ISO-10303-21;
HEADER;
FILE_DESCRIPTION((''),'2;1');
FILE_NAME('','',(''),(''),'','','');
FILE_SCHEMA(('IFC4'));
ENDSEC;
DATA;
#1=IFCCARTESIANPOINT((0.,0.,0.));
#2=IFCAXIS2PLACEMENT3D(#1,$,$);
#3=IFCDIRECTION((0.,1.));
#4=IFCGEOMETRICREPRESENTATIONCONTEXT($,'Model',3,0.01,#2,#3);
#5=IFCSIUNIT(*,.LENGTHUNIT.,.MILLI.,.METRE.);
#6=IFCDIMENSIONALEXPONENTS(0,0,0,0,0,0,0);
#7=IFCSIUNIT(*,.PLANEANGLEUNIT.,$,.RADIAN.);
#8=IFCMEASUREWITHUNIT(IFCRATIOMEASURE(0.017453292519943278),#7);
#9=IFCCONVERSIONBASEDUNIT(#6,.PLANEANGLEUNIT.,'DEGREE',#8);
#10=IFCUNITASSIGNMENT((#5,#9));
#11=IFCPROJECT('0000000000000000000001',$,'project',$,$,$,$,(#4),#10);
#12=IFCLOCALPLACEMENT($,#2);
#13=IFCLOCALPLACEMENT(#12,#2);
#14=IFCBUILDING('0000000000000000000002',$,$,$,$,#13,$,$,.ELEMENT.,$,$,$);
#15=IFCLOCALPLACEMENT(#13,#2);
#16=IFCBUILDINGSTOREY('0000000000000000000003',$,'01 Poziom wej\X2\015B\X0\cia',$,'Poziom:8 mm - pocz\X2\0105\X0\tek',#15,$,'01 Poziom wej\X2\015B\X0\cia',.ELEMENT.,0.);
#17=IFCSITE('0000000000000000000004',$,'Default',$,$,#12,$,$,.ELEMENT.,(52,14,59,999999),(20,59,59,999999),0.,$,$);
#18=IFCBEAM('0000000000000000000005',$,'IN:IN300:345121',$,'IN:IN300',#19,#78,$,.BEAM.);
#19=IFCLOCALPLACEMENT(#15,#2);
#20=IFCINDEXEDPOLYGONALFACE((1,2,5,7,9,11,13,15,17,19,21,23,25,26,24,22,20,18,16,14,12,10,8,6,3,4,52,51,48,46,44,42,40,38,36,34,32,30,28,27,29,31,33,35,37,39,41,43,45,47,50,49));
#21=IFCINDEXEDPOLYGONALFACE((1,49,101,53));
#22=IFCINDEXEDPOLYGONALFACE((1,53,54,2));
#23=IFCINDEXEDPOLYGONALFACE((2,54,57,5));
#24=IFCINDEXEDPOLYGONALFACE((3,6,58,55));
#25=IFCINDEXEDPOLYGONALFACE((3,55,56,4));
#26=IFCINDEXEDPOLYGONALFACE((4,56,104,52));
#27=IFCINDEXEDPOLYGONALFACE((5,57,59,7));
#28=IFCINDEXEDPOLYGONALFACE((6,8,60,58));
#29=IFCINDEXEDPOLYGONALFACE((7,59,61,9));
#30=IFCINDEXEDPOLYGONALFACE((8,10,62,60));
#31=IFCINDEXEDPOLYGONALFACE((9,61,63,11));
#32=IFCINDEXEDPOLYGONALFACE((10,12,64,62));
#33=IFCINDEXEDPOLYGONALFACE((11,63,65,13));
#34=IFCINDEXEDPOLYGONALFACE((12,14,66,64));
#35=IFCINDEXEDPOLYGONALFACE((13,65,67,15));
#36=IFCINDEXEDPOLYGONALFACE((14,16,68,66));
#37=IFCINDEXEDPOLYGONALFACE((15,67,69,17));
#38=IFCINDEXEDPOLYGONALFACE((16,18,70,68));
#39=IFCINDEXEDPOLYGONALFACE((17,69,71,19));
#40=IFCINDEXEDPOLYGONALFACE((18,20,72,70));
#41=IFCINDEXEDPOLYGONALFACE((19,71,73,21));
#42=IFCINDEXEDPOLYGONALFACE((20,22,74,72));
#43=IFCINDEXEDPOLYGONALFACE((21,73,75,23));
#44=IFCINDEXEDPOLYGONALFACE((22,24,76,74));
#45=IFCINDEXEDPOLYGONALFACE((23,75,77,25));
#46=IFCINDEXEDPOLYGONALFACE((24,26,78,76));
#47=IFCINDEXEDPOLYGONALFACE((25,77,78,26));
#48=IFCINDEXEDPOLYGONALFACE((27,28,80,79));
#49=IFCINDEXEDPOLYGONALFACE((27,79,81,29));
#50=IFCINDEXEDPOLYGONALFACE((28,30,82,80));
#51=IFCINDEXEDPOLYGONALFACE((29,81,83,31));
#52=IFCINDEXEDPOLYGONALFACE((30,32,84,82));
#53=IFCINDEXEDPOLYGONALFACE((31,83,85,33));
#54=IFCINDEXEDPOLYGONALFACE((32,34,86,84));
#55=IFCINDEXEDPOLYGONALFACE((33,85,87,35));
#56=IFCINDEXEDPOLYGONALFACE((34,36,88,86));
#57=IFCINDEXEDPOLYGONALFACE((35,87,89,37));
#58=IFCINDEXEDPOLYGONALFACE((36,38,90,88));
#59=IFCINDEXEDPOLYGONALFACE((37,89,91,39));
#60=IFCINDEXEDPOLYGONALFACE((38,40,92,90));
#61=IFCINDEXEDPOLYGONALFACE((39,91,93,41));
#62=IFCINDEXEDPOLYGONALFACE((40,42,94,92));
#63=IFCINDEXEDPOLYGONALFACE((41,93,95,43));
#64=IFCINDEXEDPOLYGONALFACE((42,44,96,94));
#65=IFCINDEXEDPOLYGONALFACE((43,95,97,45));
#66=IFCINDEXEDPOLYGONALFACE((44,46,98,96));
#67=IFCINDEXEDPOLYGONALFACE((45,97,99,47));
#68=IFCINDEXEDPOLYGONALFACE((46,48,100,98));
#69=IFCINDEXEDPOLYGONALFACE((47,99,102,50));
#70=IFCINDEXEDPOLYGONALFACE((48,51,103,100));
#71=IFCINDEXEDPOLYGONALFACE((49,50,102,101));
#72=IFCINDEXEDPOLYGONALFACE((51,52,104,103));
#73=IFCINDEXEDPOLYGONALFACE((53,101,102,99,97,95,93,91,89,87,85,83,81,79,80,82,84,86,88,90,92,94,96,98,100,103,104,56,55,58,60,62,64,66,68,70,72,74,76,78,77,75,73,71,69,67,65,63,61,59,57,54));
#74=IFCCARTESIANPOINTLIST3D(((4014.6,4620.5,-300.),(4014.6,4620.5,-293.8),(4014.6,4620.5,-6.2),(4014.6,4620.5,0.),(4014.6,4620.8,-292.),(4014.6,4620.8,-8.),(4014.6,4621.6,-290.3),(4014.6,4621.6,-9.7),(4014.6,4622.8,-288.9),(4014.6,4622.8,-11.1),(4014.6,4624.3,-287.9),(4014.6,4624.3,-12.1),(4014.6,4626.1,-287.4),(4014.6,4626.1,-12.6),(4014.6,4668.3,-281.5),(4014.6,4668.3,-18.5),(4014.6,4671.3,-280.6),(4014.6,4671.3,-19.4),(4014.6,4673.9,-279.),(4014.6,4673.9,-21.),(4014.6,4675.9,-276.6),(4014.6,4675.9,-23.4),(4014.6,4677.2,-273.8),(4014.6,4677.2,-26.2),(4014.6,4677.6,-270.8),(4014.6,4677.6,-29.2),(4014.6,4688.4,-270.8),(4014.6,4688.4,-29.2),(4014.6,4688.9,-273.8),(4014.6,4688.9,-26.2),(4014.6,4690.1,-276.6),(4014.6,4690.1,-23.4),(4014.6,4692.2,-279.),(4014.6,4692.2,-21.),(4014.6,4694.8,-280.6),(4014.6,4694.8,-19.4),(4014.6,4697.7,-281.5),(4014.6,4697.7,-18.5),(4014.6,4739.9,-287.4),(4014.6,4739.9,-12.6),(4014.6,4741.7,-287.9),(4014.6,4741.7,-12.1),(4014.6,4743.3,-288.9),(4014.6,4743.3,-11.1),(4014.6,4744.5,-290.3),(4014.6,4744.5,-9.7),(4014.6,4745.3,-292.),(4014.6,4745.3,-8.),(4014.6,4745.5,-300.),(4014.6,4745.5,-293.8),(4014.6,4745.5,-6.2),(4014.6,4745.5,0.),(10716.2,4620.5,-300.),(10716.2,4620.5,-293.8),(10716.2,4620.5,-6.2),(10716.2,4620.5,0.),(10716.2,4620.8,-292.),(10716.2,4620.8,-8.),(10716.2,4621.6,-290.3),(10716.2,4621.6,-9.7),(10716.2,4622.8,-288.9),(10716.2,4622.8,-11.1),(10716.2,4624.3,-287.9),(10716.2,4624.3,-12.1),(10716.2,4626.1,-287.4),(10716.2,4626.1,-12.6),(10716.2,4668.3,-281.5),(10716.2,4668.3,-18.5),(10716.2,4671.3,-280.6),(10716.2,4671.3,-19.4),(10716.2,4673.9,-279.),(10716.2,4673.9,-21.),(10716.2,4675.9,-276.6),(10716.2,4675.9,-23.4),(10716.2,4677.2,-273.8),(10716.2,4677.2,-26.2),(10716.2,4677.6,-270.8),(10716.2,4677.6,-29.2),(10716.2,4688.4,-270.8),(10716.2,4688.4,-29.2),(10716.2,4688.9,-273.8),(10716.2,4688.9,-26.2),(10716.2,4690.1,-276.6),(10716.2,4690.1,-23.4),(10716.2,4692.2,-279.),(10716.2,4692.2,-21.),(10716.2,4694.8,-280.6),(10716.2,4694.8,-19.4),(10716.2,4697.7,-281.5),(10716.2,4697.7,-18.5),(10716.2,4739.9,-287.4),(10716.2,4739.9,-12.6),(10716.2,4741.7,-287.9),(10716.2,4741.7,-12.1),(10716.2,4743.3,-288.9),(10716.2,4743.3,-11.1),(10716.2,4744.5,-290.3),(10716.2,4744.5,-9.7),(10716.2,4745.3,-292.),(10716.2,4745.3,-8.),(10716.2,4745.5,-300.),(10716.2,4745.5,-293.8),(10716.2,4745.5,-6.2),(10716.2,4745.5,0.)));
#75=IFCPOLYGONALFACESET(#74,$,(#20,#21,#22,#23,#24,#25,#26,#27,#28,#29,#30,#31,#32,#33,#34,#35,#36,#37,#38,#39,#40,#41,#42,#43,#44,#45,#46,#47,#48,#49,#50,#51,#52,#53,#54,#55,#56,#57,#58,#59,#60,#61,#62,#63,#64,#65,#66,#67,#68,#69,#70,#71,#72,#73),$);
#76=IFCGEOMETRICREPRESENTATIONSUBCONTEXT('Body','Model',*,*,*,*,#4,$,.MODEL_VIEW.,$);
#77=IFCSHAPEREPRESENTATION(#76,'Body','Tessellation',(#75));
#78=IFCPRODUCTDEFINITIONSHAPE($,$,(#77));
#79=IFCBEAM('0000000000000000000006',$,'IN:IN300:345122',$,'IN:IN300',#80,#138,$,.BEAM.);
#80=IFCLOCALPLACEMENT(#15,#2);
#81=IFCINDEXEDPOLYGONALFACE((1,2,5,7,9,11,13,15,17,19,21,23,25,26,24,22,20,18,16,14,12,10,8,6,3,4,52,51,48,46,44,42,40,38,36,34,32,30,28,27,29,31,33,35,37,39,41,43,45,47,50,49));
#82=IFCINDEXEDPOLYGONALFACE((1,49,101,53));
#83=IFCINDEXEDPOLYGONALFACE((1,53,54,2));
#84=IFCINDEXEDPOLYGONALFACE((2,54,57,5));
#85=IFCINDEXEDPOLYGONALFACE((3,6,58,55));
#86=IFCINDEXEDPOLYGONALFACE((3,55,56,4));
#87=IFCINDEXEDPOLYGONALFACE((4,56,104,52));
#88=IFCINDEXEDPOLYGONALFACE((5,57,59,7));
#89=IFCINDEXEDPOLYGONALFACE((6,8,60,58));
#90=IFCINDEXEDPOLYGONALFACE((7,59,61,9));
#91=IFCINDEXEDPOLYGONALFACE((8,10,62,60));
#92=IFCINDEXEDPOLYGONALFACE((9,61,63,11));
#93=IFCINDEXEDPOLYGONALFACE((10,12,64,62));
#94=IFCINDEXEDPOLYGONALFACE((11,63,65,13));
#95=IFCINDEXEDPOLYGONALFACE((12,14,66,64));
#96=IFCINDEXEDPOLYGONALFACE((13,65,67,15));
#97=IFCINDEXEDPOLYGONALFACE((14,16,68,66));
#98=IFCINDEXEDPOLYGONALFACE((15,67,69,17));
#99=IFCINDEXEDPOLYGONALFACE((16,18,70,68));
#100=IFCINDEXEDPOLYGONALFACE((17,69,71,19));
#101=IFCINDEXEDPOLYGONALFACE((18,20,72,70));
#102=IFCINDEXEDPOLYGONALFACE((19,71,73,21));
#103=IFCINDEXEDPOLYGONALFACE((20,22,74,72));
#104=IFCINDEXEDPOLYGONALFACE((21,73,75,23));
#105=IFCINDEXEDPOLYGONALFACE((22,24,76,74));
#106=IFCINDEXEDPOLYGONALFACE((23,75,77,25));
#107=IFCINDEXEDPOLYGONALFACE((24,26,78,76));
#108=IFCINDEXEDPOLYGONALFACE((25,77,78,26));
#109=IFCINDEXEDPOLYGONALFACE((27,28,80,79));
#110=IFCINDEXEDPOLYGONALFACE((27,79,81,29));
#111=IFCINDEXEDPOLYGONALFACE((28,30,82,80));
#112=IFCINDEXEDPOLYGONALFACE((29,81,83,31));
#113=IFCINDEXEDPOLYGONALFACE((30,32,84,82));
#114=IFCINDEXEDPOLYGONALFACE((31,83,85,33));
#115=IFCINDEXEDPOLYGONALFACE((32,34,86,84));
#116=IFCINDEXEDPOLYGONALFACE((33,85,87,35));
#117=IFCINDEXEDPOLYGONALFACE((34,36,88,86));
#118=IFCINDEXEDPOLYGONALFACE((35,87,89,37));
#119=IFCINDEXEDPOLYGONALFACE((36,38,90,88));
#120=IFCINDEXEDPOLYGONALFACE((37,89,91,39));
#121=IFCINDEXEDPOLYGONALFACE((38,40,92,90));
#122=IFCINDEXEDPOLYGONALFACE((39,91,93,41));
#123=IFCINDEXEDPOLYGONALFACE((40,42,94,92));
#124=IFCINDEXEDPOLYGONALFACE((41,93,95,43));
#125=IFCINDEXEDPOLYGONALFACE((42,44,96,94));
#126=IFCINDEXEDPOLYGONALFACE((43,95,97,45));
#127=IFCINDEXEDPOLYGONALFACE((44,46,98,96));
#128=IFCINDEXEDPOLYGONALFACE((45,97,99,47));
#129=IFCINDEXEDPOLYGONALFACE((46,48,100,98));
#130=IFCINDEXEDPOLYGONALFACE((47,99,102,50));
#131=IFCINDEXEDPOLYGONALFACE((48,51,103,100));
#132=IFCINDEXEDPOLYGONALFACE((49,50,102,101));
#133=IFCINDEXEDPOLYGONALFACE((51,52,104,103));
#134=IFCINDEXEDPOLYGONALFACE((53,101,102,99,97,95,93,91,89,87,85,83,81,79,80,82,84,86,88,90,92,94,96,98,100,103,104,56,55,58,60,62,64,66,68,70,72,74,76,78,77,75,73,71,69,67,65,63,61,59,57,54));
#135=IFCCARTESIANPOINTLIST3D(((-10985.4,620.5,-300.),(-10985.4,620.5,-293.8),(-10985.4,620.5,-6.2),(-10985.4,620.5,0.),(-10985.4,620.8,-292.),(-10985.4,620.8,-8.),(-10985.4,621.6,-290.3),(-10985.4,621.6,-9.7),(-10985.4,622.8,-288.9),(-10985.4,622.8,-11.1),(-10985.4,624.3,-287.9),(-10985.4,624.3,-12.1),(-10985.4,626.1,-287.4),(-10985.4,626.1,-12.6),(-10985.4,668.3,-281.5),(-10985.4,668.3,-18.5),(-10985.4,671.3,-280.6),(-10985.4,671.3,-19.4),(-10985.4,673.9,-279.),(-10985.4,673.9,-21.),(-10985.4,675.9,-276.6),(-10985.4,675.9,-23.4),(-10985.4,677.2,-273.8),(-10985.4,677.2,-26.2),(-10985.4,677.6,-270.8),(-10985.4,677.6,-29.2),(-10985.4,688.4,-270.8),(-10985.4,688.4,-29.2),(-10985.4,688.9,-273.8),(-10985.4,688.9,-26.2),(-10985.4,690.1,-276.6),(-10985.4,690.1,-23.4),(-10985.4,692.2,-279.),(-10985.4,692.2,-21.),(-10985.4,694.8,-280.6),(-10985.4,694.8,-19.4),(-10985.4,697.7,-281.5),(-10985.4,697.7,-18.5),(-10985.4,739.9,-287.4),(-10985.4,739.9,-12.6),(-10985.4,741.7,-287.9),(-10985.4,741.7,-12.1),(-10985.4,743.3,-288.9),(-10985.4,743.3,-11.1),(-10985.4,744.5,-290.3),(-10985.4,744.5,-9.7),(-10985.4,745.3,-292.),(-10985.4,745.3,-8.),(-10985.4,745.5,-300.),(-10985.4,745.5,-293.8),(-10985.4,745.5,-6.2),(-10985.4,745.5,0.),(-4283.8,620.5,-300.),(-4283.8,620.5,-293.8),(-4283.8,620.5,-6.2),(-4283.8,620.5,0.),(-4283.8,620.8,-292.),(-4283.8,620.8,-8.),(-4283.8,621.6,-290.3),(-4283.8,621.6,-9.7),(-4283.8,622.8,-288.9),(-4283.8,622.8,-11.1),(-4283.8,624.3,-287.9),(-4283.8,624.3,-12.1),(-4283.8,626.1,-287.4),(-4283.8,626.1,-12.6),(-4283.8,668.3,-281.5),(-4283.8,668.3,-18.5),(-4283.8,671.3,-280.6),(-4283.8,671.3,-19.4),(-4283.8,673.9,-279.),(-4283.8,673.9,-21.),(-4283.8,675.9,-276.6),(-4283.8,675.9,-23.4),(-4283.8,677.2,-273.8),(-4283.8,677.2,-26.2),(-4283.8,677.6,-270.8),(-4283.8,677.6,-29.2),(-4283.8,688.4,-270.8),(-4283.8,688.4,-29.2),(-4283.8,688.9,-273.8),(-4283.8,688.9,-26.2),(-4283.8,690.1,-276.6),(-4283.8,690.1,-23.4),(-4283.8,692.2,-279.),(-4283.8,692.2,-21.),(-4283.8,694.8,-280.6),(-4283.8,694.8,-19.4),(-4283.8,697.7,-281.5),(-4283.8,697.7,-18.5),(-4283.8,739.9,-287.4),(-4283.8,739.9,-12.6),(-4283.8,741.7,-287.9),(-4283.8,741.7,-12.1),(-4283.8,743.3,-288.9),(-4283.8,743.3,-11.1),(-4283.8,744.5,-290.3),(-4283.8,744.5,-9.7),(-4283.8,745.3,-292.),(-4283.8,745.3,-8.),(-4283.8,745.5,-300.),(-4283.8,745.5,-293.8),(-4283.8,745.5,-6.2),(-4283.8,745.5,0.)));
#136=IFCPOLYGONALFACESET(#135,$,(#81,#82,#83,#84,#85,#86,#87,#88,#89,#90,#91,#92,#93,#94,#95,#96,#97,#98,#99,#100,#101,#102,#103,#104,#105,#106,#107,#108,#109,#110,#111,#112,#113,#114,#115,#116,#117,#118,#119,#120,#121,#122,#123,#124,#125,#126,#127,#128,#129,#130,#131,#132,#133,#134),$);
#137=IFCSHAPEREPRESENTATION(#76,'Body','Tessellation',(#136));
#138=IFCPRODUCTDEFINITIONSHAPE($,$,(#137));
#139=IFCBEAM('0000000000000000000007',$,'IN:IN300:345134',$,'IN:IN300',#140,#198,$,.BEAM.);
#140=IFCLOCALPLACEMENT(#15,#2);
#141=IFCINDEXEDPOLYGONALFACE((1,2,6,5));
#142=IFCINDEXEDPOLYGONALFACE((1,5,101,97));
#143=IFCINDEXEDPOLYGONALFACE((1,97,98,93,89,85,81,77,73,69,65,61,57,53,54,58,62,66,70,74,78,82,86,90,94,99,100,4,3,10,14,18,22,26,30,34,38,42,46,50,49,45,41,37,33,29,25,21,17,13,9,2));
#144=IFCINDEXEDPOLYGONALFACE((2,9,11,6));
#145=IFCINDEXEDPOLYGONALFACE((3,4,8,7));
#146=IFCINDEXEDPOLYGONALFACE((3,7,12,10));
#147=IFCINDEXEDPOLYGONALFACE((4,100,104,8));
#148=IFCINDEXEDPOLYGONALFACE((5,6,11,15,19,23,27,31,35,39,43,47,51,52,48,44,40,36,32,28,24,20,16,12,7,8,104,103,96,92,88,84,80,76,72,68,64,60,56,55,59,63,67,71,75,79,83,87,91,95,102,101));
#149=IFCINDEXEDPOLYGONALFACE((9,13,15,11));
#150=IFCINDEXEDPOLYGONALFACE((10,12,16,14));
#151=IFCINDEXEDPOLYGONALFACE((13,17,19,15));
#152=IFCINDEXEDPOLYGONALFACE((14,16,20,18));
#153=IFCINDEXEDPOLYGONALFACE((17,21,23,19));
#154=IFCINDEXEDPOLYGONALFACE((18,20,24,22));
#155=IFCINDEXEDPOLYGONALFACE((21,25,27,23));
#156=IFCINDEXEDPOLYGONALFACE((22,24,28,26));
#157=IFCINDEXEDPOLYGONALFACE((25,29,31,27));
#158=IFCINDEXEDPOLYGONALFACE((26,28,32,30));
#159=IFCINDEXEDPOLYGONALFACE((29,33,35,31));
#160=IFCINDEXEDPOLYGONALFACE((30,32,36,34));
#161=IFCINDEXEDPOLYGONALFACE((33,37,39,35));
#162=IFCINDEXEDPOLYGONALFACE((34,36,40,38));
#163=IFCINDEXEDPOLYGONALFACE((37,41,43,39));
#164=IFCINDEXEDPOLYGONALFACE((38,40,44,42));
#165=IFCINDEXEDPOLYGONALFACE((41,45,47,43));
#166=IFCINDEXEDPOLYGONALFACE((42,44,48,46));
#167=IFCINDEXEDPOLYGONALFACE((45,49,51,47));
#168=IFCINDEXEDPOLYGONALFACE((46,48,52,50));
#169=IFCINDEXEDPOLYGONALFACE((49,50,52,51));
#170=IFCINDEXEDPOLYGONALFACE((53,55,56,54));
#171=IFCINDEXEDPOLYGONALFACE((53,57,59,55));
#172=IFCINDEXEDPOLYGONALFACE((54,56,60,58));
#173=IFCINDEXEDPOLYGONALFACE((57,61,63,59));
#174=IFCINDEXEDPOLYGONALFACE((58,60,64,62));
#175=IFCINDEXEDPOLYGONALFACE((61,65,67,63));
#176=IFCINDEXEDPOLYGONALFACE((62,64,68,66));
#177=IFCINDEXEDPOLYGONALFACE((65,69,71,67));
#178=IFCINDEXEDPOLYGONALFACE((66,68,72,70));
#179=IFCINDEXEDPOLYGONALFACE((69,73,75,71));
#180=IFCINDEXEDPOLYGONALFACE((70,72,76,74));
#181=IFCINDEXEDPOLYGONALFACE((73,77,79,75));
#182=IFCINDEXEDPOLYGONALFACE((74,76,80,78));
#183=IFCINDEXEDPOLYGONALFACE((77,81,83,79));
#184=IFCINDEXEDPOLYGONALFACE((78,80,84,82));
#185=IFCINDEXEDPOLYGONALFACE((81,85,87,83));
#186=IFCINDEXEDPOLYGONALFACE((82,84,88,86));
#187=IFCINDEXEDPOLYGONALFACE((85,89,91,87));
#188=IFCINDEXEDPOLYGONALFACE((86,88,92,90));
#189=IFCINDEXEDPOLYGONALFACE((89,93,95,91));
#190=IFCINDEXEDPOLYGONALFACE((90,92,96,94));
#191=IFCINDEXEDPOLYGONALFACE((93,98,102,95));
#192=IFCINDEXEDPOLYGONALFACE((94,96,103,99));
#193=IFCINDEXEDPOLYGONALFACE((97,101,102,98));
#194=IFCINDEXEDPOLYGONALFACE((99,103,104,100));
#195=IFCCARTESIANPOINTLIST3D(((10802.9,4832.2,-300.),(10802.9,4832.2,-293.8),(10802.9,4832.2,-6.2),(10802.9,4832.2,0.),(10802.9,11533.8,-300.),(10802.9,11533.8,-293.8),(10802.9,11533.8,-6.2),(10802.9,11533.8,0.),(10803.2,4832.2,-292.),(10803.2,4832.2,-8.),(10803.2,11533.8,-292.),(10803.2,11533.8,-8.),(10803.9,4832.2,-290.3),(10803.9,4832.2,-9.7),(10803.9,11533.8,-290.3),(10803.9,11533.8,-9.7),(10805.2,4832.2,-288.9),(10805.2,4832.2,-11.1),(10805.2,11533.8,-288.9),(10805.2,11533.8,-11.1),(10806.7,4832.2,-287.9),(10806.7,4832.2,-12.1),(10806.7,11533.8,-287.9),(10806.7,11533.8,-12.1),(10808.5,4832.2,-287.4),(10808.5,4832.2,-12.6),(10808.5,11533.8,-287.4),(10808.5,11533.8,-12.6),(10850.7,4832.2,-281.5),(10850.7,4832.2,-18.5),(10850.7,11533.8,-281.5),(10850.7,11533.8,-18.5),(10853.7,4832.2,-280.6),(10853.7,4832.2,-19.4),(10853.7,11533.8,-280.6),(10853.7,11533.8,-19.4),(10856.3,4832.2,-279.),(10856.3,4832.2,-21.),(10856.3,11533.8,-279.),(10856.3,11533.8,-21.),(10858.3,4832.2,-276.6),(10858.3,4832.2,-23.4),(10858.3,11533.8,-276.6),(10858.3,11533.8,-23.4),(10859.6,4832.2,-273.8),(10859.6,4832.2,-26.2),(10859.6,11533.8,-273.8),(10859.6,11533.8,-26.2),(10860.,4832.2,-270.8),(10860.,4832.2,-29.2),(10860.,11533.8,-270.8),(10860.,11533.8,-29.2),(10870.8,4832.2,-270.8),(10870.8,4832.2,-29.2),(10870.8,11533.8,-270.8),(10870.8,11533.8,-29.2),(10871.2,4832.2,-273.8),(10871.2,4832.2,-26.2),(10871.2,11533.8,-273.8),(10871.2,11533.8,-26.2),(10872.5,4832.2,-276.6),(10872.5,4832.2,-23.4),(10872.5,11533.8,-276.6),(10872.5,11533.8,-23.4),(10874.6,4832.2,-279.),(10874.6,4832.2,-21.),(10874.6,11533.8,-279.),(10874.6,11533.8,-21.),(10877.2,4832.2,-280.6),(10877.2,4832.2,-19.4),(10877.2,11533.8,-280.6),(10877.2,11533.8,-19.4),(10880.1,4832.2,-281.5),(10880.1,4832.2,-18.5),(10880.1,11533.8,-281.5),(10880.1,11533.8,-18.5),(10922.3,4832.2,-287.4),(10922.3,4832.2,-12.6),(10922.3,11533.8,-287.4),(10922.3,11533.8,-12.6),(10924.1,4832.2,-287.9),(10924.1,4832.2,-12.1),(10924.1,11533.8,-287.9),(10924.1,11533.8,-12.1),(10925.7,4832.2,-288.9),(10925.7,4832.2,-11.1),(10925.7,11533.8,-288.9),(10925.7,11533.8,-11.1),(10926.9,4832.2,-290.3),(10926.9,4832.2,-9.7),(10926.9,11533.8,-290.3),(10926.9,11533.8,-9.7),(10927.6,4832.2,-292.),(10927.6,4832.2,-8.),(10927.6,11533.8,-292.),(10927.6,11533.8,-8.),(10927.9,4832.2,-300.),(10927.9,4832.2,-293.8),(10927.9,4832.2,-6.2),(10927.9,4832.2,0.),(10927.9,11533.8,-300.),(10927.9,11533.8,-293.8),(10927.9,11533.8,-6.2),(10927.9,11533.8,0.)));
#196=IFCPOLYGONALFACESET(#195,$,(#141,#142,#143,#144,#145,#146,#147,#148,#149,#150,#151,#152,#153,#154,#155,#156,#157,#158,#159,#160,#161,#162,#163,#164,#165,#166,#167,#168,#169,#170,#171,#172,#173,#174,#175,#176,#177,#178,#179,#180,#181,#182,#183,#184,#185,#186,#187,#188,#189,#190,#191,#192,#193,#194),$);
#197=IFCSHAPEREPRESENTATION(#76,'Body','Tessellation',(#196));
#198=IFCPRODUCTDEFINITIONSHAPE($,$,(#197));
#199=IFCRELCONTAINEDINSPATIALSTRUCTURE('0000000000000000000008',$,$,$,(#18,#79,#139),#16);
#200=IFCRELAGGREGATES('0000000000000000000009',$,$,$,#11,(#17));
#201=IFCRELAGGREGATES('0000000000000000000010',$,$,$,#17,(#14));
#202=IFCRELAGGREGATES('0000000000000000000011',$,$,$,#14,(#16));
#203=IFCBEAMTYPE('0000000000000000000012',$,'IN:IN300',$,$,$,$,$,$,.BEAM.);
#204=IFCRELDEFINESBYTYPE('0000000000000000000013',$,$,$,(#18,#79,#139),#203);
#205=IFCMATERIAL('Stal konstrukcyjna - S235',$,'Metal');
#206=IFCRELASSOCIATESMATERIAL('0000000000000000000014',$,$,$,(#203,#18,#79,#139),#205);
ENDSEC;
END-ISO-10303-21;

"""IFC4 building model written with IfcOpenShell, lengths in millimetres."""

from ifc_helpers import new_model, entity, si_unit, converted_unit, direction, frame, origin, place, context, subcontext, project, spatial, line, arc, indexed_curve, outline, extrude, source, transform, mapped, material, type_object, type_shapes, element, save


model = new_model("IFC4")

# Units and contexts
model_context = context("Model", 3, precision=0.01, world=origin(), true_north=direction((0.0, 1.0)))
body_context = subcontext(model_context, "Body", "Model", "MODEL_VIEW")
ifc_project = project(units=[si_unit("LENGTHUNIT", "METRE", prefix="MILLI"), converted_unit("PLANEANGLEUNIT", "DEGREE", entity("IfcRatioMeasure", 0.017453292519943278), si_unit("PLANEANGLEUNIT", "RADIAN"), dimensions=[0, 0, 0, 0, 0, 0, 0])], contexts=[model_context])

# Site, building, storey
site_placement = place(None, origin())
site = spatial("IfcSite", under=ifc_project, at=site_placement, Name="Default", CompositionType="ELEMENT", RefLatitude=(52, 14, 59, 999999), RefLongitude=(20, 59, 59, 999999), RefElevation=0.0)
building_placement = place(site_placement, origin())
building = spatial("IfcBuilding", under=site, at=building_placement, CompositionType="ELEMENT")
storey_placement = place(building_placement, origin())
storey = spatial("IfcBuildingStorey", under=building, at=storey_placement, Name="01 Poziom wejścia", ObjectType="Poziom:8 mm - początek", LongName="01 Poziom wejścia", CompositionType="ELEMENT", Elevation=0.0)

# Beams
ifc_material = material(Name="Stal konstrukcyjna - S235", Category="Metal")
beam_type_1 = type_object("IfcBeamType", Name="IN:IN300", PredefinedType="BEAM", material=ifc_material)
shared_shape_1 = source(origin(), body_context, "Body", "SweptSolid", [
    extrude(outline(indexed_curve([(143.8, -62.5), (150.0, -62.5), (150.0, 62.5), (143.8, 62.5), (139.6, 60.9), (137.4, 56.9), (131.5, 14.7), (127.9, 8.1), (120.8, 5.4), (-120.8, 5.4), (-127.9, 8.1), (-131.5, 14.7), (-137.4, 56.9), (-139.6, 60.9), (-143.8, 62.5), (-150.0, 62.5), (-150.0, -62.5), (-143.8, -62.5), (-139.6, -60.9), (-137.4, -56.9), (-131.5, -14.7), (-127.9, -8.1), (-120.8, -5.4), (120.8, -5.4), (127.9, -8.1), (131.5, -14.7), (137.4, -56.9), (139.6, -60.9)], segments=[line(1, 2, 3, 4), arc(4, 5, 6), line(6, 7), arc(7, 8, 9), line(9, 10), arc(10, 11, 12), line(12, 13), arc(13, 14, 15), line(15, 16, 17, 18), arc(18, 19, 20), line(20, 21), arc(21, 22, 23), line(23, 24), arc(24, 25, 26), line(26, 27), arc(27, 28, 1)], self_intersect=False)), frame((-3350.8, 0.0, 0.0), z_axis=(1.0, 0.0, 0.0), x_axis=(0.0, 0.0, -1.0)), (0.0, 0.0, 1.0), 6701.6),
])
type_shapes(beam_type_1, [shared_shape_1])
for number, where, name in (
    (1, (7365.4, 4683.0, -150.0), "IN:IN300:345121"),
    (2, (-7634.6, 683.0, -150.0), "IN:IN300:345122"),
):
    element("IfcBeam", number, at=place(storey_placement, frame(where)), inside=storey, type_object=beam_type_1, material=ifc_material, Name=name, ObjectType="IN:IN300", PredefinedType="BEAM", context=body_context, shape_type="MappedRepresentation", body=[
        mapped(shared_shape_1, transform((0.0, 0.0, 0.0), scale=1.0)),
    ])
for number, where, z_axis, x_axis, name in (
    (3, (10865.4, 8183.0, -150.0), (0.0, 0.0, 1.0), (0.0, -1.0, 0.0), "IN:IN300:345134"),
):
    element("IfcBeam", number, at=place(storey_placement, frame(where, z_axis=z_axis, x_axis=x_axis)), inside=storey, type_object=beam_type_1, material=ifc_material, Name=name, ObjectType="IN:IN300", PredefinedType="BEAM", context=body_context, shape_type="MappedRepresentation", body=[
        mapped(shared_shape_1, transform((0.0, 0.0, 0.0), scale=1.0)),
    ])

save(model, "model.ifc")
